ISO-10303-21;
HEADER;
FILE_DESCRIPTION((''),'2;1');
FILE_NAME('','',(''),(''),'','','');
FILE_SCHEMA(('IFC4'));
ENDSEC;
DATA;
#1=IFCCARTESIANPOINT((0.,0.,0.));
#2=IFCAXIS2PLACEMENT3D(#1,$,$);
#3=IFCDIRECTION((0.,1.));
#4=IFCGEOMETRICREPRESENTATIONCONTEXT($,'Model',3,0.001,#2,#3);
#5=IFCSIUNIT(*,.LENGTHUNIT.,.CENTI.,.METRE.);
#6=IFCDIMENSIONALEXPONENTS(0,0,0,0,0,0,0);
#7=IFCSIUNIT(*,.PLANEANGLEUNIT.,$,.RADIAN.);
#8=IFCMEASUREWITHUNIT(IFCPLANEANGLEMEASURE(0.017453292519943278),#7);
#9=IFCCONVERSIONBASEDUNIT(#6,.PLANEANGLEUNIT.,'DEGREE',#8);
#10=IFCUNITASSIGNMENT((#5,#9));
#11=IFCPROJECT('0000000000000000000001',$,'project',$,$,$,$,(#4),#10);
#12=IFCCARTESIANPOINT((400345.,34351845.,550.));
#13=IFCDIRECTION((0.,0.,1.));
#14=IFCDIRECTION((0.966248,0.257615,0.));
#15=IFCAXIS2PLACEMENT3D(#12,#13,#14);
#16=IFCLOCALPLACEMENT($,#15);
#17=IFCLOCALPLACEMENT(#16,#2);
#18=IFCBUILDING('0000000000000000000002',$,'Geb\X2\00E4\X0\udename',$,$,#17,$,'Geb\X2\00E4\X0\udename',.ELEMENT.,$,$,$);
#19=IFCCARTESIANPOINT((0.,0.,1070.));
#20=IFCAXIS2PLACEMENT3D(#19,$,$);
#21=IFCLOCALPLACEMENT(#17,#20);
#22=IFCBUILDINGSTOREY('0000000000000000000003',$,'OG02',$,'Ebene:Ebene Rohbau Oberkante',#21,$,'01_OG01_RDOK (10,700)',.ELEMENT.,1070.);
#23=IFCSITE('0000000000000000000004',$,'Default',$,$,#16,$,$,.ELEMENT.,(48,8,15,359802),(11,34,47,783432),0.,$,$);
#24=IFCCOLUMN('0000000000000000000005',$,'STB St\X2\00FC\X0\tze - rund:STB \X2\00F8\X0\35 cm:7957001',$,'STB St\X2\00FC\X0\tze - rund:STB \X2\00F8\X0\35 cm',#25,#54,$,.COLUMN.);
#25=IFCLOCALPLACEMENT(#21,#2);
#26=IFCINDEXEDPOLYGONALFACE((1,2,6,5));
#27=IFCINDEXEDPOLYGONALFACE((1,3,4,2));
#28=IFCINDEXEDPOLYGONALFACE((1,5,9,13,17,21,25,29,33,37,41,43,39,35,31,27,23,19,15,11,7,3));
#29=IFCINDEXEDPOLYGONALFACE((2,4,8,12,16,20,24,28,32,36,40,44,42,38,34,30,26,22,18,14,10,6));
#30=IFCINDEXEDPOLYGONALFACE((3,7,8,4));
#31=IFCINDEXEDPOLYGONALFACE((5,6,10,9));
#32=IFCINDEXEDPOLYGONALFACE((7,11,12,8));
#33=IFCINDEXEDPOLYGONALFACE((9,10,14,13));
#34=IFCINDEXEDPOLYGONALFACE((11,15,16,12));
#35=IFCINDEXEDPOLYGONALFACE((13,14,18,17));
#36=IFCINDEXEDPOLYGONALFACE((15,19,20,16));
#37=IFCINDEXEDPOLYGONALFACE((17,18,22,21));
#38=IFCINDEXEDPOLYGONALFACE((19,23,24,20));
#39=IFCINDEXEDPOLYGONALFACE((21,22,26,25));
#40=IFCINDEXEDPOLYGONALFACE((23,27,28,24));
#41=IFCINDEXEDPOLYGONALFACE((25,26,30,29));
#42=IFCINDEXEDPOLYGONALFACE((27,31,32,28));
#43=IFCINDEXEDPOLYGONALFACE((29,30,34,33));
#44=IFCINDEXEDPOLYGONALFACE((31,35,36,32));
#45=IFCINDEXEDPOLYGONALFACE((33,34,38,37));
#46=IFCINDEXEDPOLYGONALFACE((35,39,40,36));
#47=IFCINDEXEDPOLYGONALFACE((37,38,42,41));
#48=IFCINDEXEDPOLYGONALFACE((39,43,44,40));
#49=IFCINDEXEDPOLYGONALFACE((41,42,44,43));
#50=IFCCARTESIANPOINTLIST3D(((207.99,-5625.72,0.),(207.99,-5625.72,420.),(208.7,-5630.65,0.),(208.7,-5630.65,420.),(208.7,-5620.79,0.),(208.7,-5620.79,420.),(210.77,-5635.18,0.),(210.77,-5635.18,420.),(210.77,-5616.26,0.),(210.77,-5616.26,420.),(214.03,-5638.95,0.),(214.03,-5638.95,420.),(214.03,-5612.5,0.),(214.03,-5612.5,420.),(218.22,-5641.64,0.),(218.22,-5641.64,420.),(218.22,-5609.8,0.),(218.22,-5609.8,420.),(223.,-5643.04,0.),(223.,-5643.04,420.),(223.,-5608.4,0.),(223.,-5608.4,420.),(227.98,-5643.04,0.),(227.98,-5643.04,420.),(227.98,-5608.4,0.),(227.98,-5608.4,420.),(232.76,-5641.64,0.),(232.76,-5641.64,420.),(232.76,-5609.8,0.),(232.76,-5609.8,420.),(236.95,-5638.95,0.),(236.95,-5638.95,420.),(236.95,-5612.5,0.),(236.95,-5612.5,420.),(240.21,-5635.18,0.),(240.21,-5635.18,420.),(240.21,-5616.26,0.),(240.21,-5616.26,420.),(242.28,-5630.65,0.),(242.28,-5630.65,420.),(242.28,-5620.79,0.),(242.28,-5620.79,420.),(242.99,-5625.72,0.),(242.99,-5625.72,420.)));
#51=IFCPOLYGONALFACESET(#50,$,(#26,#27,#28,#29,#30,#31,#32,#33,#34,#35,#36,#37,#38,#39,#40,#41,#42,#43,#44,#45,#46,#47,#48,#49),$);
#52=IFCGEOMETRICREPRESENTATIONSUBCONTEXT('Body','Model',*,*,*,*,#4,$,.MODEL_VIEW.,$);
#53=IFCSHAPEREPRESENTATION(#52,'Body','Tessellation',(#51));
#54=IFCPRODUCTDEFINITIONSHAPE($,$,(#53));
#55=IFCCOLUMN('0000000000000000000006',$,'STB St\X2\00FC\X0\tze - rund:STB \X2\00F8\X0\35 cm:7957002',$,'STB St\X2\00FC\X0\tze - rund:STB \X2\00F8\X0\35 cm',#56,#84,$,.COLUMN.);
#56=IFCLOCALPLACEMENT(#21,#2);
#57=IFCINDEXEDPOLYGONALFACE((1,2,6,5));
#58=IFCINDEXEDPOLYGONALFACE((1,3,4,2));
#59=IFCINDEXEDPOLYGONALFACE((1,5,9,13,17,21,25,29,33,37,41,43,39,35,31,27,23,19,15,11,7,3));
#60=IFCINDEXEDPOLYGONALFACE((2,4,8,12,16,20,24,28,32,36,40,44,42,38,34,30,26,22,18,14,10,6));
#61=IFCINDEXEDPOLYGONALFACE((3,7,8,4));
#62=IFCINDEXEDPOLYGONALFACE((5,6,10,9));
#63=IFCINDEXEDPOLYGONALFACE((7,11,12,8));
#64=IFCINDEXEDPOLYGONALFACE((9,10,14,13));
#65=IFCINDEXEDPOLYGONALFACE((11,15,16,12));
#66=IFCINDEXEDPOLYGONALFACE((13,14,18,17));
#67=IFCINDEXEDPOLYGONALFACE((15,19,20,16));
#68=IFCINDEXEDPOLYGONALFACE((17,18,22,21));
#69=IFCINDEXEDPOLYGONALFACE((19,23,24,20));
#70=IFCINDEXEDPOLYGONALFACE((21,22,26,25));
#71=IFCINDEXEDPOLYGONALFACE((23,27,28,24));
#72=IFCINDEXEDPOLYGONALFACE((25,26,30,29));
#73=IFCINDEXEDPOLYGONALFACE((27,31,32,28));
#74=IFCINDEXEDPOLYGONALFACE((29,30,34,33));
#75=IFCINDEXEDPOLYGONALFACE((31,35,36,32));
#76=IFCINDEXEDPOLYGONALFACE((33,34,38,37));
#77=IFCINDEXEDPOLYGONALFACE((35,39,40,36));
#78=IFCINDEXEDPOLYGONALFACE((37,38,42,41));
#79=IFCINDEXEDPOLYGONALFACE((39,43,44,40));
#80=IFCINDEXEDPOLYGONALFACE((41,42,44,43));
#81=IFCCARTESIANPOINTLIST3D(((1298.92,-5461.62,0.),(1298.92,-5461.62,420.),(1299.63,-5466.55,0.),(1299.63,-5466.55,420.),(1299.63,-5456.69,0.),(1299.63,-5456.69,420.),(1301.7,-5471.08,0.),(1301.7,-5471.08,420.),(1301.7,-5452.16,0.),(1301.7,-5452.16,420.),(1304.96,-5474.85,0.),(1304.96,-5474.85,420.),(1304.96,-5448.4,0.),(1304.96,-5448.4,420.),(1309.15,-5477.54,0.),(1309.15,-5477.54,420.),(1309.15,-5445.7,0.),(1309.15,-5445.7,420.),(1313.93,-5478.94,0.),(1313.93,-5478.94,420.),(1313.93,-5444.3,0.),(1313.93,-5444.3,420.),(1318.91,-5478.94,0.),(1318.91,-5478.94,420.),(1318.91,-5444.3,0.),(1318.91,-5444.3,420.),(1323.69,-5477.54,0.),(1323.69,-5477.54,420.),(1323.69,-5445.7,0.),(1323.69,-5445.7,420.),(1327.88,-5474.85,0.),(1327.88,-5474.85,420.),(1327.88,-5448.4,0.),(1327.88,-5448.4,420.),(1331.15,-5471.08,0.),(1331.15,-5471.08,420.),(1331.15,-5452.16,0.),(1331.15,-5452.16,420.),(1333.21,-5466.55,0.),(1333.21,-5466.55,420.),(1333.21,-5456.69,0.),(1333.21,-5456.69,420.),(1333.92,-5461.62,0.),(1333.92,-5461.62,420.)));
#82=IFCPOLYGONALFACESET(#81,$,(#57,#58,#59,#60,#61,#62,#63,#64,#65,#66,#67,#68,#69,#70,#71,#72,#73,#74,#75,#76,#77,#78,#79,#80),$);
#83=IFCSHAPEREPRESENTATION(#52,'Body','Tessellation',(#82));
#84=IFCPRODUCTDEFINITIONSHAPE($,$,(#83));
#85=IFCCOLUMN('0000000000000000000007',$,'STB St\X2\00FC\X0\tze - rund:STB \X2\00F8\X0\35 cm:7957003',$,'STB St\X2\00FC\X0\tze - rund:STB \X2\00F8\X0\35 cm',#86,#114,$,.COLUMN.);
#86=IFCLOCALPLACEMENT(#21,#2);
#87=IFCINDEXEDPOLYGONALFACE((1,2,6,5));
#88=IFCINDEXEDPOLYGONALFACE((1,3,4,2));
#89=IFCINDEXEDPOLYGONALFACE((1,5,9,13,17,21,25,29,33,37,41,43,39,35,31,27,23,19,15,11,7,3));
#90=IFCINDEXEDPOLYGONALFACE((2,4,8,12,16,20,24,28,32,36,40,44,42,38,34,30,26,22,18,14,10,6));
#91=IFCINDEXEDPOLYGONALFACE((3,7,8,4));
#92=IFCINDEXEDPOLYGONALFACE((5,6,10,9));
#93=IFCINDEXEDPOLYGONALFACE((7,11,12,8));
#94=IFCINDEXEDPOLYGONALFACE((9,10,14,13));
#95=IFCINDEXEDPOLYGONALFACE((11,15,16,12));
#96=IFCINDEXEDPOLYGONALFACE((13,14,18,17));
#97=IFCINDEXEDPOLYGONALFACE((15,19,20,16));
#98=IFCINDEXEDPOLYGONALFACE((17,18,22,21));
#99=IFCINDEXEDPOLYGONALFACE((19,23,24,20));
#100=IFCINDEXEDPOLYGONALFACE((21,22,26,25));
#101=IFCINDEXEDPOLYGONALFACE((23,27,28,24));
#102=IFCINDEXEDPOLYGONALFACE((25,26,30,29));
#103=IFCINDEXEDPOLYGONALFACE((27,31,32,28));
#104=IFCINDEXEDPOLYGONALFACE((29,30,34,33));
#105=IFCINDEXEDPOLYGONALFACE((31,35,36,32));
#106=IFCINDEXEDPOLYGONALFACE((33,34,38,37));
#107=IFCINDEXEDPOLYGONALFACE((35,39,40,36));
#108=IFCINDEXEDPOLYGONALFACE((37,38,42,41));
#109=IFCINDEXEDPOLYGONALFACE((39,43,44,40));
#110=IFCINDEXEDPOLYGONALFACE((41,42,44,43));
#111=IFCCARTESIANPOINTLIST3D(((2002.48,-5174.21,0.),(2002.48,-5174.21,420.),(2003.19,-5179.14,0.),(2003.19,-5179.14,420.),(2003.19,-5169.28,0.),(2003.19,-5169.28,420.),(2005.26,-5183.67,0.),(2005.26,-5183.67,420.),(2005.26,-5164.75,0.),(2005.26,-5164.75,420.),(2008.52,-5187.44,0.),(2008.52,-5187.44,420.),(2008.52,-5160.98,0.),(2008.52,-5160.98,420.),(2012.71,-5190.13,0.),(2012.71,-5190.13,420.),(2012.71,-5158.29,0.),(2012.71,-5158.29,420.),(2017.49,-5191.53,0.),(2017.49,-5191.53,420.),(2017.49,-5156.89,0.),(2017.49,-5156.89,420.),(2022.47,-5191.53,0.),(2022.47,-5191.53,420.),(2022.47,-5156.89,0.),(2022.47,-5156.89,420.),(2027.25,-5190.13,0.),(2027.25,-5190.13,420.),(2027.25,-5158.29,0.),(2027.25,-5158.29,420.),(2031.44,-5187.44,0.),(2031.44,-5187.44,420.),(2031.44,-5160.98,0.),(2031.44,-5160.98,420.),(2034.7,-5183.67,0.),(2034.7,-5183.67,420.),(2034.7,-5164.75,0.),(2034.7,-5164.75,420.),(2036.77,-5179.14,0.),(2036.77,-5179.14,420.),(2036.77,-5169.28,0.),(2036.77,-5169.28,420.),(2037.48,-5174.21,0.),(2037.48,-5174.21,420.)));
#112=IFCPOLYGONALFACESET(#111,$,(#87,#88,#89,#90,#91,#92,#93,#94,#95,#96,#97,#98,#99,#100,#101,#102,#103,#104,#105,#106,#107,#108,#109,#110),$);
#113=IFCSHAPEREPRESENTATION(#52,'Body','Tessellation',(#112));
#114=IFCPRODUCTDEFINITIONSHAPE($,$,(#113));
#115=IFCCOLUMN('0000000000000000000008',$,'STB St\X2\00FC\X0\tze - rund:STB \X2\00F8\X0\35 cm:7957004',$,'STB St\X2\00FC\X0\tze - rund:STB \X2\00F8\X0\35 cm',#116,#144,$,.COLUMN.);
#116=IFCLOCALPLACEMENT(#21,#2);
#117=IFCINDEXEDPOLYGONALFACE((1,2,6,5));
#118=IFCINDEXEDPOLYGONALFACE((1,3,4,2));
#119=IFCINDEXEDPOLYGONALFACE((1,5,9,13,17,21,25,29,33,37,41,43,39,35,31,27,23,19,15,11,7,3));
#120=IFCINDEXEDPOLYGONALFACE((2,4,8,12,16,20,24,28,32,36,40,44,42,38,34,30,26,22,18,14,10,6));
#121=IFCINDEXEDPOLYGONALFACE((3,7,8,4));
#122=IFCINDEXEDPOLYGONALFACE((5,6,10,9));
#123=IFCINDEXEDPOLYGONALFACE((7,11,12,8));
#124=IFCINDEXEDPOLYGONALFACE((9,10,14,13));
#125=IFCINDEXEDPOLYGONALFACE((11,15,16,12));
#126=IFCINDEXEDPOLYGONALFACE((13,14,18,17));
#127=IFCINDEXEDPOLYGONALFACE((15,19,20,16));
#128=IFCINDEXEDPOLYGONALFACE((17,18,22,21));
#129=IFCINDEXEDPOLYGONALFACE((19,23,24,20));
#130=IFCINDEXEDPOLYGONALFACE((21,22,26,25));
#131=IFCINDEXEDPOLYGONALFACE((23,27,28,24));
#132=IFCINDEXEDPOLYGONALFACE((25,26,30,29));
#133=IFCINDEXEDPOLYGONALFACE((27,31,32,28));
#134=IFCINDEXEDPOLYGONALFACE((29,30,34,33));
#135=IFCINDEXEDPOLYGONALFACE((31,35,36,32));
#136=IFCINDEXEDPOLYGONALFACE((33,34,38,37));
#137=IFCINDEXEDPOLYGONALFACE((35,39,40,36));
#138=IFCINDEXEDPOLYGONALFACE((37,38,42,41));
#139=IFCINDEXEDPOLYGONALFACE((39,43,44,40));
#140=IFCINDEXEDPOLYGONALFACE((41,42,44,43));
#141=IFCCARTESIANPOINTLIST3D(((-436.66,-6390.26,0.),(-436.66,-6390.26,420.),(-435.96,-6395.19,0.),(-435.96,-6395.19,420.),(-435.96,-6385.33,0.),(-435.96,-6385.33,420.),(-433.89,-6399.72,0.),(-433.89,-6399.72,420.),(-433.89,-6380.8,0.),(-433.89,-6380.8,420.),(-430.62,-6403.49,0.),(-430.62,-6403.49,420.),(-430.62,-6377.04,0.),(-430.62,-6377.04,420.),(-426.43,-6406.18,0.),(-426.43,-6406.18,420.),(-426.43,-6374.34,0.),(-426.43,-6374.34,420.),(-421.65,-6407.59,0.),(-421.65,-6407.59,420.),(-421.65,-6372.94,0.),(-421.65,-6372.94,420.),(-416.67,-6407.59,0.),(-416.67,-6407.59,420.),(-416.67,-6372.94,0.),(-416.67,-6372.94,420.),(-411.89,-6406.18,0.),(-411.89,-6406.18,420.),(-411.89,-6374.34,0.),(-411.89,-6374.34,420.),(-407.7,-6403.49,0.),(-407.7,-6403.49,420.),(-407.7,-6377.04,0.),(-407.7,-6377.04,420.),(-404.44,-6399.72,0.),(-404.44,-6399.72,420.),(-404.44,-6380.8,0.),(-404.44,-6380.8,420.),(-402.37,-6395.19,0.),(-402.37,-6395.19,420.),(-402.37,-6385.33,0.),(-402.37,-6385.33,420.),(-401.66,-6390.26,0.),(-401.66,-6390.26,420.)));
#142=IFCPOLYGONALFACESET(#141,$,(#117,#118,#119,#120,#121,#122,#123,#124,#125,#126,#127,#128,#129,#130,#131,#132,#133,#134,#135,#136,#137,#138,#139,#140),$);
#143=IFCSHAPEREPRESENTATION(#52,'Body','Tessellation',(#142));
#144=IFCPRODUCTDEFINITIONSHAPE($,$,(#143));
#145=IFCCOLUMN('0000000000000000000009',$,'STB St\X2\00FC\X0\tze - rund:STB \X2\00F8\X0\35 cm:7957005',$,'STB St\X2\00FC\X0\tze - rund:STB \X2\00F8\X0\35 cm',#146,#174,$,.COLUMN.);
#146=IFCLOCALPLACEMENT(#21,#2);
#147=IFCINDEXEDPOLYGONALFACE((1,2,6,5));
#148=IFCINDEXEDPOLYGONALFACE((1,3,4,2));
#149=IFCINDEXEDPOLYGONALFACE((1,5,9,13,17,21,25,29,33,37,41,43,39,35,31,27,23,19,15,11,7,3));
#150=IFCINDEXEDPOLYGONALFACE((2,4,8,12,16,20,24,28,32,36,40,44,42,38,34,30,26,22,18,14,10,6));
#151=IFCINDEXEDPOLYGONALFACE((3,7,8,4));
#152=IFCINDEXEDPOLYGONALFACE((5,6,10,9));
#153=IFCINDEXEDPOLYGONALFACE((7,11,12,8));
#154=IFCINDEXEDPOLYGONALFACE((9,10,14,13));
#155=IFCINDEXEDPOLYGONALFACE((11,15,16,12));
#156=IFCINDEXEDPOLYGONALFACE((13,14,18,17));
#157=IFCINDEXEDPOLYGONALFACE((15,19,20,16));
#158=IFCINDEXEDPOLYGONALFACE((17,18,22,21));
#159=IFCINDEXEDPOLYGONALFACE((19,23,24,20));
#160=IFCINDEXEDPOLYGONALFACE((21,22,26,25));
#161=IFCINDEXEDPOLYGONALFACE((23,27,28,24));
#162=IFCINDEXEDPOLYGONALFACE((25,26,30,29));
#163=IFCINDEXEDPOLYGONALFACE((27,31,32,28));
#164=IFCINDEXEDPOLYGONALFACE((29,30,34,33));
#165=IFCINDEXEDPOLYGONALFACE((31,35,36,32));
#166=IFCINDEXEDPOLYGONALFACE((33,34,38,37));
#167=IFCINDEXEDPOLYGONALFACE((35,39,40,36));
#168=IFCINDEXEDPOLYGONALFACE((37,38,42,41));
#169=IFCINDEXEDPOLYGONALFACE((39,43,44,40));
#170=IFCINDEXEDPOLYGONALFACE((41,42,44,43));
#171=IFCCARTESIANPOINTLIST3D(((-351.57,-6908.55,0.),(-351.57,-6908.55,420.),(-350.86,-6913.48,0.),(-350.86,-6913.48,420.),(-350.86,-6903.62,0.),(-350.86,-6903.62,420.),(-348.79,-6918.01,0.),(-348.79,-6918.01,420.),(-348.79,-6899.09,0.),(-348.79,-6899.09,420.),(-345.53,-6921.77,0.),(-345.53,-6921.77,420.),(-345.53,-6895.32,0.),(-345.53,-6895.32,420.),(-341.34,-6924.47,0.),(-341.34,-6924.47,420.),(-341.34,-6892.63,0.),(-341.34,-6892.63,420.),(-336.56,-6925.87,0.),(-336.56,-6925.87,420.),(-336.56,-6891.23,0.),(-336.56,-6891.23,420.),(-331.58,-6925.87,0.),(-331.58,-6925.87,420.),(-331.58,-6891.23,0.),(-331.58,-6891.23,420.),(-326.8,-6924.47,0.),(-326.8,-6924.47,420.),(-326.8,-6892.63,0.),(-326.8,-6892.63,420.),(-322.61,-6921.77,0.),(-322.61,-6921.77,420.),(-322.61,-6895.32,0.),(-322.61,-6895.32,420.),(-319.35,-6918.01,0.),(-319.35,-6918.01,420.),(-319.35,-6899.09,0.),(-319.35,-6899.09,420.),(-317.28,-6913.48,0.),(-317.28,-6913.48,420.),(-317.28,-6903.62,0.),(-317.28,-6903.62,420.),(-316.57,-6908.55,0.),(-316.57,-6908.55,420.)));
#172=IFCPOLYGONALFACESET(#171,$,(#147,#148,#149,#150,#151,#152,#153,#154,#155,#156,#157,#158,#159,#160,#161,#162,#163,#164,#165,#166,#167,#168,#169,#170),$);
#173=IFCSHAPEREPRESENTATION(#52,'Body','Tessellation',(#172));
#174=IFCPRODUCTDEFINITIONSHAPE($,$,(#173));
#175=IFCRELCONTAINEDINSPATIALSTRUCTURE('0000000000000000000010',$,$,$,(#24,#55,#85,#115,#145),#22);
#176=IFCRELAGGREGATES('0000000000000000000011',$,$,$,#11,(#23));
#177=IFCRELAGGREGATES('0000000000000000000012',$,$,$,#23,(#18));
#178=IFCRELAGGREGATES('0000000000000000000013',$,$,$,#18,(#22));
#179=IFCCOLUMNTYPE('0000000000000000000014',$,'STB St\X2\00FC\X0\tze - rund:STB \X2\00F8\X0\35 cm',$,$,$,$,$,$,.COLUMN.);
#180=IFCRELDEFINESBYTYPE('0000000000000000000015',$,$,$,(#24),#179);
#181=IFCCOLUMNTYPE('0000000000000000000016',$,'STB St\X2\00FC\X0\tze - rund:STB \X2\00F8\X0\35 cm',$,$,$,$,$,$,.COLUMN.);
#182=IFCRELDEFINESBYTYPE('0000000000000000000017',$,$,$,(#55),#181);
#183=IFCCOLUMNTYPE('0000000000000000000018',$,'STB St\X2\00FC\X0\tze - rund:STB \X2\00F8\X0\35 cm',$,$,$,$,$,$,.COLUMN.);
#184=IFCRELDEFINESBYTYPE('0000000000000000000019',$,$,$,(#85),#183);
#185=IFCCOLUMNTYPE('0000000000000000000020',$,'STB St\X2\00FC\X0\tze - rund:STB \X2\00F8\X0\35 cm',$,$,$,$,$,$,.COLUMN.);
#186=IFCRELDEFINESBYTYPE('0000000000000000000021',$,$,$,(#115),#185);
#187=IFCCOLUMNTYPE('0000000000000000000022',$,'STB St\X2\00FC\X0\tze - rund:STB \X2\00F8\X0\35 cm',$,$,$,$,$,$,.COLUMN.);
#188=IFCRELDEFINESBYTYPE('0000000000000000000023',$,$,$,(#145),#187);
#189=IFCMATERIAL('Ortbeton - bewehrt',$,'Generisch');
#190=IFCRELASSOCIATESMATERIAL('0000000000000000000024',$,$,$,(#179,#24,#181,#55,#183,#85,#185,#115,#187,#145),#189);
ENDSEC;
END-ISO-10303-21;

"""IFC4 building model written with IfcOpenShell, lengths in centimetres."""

from ifc_helpers import new_model, entity, si_unit, converted_unit, direction, frame, origin, place, context, subcontext, project, spatial, arc, indexed_curve, outline, extrude, source, transform, mapped, material, type_object, type_shapes, element, save


model = new_model("IFC4")

# Units and contexts
model_context = context("Model", 3, precision=0.001, world=origin(), true_north=direction((0.0, 1.0)))
body_context = subcontext(model_context, "Body", "Model", "MODEL_VIEW")
ifc_project = project(units=[si_unit("LENGTHUNIT", "METRE", prefix="CENTI"), converted_unit("PLANEANGLEUNIT", "DEGREE", entity("IfcPlaneAngleMeasure", 0.017453292519943278), si_unit("PLANEANGLEUNIT", "RADIAN"), dimensions=[0, 0, 0, 0, 0, 0, 0])], contexts=[model_context])

# Site, building, storey
site_placement = place(None, frame((400345.0, 34351845.0, 550.0), z_axis=(0.0, 0.0, 1.0), x_axis=(0.966248, 0.257615, 0.0)))
site = spatial("IfcSite", under=ifc_project, at=site_placement, Name="Default", CompositionType="ELEMENT", RefLatitude=(48, 8, 15, 359802), RefLongitude=(11, 34, 47, 783432), RefElevation=0.0)
building_placement = place(site_placement, origin())
building = spatial("IfcBuilding", under=site, at=building_placement, Name="Gebäudename", LongName="Gebäudename", CompositionType="ELEMENT")
storey_placement = place(building_placement, frame((0.0, 0.0, 1070.0)))
storey = spatial("IfcBuildingStorey", under=building, at=storey_placement, Name="OG02", ObjectType="Ebene:Ebene Rohbau Oberkante", LongName="01_OG01_RDOK (10,700)", CompositionType="ELEMENT", Elevation=1070.0)

# Columns
ifc_material = material(Name="Ortbeton - bewehrt", Category="Generisch")
column_type_1 = type_object("IfcColumnType", Name="STB Stütze - rund:STB ø35 cm", PredefinedType="COLUMN", material=ifc_material)
shared_shape_1 = source(origin(), body_context, "Body", "SweptSolid", [
    extrude(outline(indexed_curve([(-17.5, 0.0), (0.0, -17.5), (17.5, 0.0), (0.0, 17.5)], segments=[arc(1, 2, 3), arc(3, 4, 1)], self_intersect=False)), frame((225.49, -5625.72, 1070.0)), (0.0, 0.0, 1.0), 420.0),
])
type_shapes(column_type_1, [shared_shape_1])
column_1_placement = place(storey_placement, frame((0.0, 0.0, -1070.0)))
element("IfcColumn", 1, at=column_1_placement, inside=storey, type_object=column_type_1, material=ifc_material, Name="STB Stütze - rund:STB ø35 cm:7957001", ObjectType="STB Stütze - rund:STB ø35 cm", PredefinedType="COLUMN", context=body_context, shape_type="MappedRepresentation", body=[
    mapped(shared_shape_1, transform((0.0, 0.0, 0.0), scale=1.0)),
])
column_type_2 = type_object("IfcColumnType", Name="STB Stütze - rund:STB ø35 cm", PredefinedType="COLUMN", material=ifc_material)
shared_shape_2 = source(origin(), body_context, "Body", "SweptSolid", [
    extrude(outline(indexed_curve([(-17.5, 0.0), (0.0, -17.5), (17.5, 0.0), (0.0, 17.5)], segments=[arc(1, 2, 3), arc(3, 4, 1)], self_intersect=False)), frame((1316.42, -5461.62, 1070.0)), (0.0, 0.0, 1.0), 420.0),
])
type_shapes(column_type_2, [shared_shape_2])
column_2_placement = place(storey_placement, frame((0.0, 0.0, -1070.0)))
element("IfcColumn", 2, at=column_2_placement, inside=storey, type_object=column_type_2, material=ifc_material, Name="STB Stütze - rund:STB ø35 cm:7957002", ObjectType="STB Stütze - rund:STB ø35 cm", PredefinedType="COLUMN", context=body_context, shape_type="MappedRepresentation", body=[
    mapped(shared_shape_2, transform((0.0, 0.0, 0.0), scale=1.0)),
])
column_type_3 = type_object("IfcColumnType", Name="STB Stütze - rund:STB ø35 cm", PredefinedType="COLUMN", material=ifc_material)
shared_shape_3 = source(origin(), body_context, "Body", "SweptSolid", [
    extrude(outline(indexed_curve([(-17.5, 0.0), (0.0, -17.5), (17.5, 0.0), (0.0, 17.5)], segments=[arc(1, 2, 3), arc(3, 4, 1)], self_intersect=False)), frame((2019.98, -5174.21, 1070.0)), (0.0, 0.0, 1.0), 420.0),
])
type_shapes(column_type_3, [shared_shape_3])
column_3_placement = place(storey_placement, frame((0.0, 0.0, -1070.0)))
element("IfcColumn", 3, at=column_3_placement, inside=storey, type_object=column_type_3, material=ifc_material, Name="STB Stütze - rund:STB ø35 cm:7957003", ObjectType="STB Stütze - rund:STB ø35 cm", PredefinedType="COLUMN", context=body_context, shape_type="MappedRepresentation", body=[
    mapped(shared_shape_3, transform((0.0, 0.0, 0.0), scale=1.0)),
])
column_type_4 = type_object("IfcColumnType", Name="STB Stütze - rund:STB ø35 cm", PredefinedType="COLUMN", material=ifc_material)
shared_shape_4 = source(origin(), body_context, "Body", "SweptSolid", [
    extrude(outline(indexed_curve([(-17.5, 0.0), (0.0, -17.5), (17.5, 0.0), (0.0, 17.5)], segments=[arc(1, 2, 3), arc(3, 4, 1)], self_intersect=False)), frame((-419.16, -6390.26, 1070.0)), (0.0, 0.0, 1.0), 420.0),
])
type_shapes(column_type_4, [shared_shape_4])
column_4_placement = place(storey_placement, frame((0.0, 0.0, -1070.0)))
element("IfcColumn", 4, at=column_4_placement, inside=storey, type_object=column_type_4, material=ifc_material, Name="STB Stütze - rund:STB ø35 cm:7957004", ObjectType="STB Stütze - rund:STB ø35 cm", PredefinedType="COLUMN", context=body_context, shape_type="MappedRepresentation", body=[
    mapped(shared_shape_4, transform((0.0, 0.0, 0.0), scale=1.0)),
])
column_type_5 = type_object("IfcColumnType", Name="STB Stütze - rund:STB ø35 cm", PredefinedType="COLUMN", material=ifc_material)
shared_shape_5 = source(origin(), body_context, "Body", "SweptSolid", [
    extrude(outline(indexed_curve([(-17.5, 0.0), (0.0, -17.5), (17.5, 0.0), (0.0, 17.5)], segments=[arc(1, 2, 3), arc(3, 4, 1)], self_intersect=False)), frame((-334.07, -6908.55, 1070.0)), (0.0, 0.0, 1.0), 420.0),
])
type_shapes(column_type_5, [shared_shape_5])
column_5_placement = place(storey_placement, frame((0.0, 0.0, -1070.0)))
element("IfcColumn", 5, at=column_5_placement, inside=storey, type_object=column_type_5, material=ifc_material, Name="STB Stütze - rund:STB ø35 cm:7957005", ObjectType="STB Stütze - rund:STB ø35 cm", PredefinedType="COLUMN", context=body_context, shape_type="MappedRepresentation", body=[
    mapped(shared_shape_5, transform((0.0, 0.0, 0.0), scale=1.0)),
])

save(model, "model.ifc")
